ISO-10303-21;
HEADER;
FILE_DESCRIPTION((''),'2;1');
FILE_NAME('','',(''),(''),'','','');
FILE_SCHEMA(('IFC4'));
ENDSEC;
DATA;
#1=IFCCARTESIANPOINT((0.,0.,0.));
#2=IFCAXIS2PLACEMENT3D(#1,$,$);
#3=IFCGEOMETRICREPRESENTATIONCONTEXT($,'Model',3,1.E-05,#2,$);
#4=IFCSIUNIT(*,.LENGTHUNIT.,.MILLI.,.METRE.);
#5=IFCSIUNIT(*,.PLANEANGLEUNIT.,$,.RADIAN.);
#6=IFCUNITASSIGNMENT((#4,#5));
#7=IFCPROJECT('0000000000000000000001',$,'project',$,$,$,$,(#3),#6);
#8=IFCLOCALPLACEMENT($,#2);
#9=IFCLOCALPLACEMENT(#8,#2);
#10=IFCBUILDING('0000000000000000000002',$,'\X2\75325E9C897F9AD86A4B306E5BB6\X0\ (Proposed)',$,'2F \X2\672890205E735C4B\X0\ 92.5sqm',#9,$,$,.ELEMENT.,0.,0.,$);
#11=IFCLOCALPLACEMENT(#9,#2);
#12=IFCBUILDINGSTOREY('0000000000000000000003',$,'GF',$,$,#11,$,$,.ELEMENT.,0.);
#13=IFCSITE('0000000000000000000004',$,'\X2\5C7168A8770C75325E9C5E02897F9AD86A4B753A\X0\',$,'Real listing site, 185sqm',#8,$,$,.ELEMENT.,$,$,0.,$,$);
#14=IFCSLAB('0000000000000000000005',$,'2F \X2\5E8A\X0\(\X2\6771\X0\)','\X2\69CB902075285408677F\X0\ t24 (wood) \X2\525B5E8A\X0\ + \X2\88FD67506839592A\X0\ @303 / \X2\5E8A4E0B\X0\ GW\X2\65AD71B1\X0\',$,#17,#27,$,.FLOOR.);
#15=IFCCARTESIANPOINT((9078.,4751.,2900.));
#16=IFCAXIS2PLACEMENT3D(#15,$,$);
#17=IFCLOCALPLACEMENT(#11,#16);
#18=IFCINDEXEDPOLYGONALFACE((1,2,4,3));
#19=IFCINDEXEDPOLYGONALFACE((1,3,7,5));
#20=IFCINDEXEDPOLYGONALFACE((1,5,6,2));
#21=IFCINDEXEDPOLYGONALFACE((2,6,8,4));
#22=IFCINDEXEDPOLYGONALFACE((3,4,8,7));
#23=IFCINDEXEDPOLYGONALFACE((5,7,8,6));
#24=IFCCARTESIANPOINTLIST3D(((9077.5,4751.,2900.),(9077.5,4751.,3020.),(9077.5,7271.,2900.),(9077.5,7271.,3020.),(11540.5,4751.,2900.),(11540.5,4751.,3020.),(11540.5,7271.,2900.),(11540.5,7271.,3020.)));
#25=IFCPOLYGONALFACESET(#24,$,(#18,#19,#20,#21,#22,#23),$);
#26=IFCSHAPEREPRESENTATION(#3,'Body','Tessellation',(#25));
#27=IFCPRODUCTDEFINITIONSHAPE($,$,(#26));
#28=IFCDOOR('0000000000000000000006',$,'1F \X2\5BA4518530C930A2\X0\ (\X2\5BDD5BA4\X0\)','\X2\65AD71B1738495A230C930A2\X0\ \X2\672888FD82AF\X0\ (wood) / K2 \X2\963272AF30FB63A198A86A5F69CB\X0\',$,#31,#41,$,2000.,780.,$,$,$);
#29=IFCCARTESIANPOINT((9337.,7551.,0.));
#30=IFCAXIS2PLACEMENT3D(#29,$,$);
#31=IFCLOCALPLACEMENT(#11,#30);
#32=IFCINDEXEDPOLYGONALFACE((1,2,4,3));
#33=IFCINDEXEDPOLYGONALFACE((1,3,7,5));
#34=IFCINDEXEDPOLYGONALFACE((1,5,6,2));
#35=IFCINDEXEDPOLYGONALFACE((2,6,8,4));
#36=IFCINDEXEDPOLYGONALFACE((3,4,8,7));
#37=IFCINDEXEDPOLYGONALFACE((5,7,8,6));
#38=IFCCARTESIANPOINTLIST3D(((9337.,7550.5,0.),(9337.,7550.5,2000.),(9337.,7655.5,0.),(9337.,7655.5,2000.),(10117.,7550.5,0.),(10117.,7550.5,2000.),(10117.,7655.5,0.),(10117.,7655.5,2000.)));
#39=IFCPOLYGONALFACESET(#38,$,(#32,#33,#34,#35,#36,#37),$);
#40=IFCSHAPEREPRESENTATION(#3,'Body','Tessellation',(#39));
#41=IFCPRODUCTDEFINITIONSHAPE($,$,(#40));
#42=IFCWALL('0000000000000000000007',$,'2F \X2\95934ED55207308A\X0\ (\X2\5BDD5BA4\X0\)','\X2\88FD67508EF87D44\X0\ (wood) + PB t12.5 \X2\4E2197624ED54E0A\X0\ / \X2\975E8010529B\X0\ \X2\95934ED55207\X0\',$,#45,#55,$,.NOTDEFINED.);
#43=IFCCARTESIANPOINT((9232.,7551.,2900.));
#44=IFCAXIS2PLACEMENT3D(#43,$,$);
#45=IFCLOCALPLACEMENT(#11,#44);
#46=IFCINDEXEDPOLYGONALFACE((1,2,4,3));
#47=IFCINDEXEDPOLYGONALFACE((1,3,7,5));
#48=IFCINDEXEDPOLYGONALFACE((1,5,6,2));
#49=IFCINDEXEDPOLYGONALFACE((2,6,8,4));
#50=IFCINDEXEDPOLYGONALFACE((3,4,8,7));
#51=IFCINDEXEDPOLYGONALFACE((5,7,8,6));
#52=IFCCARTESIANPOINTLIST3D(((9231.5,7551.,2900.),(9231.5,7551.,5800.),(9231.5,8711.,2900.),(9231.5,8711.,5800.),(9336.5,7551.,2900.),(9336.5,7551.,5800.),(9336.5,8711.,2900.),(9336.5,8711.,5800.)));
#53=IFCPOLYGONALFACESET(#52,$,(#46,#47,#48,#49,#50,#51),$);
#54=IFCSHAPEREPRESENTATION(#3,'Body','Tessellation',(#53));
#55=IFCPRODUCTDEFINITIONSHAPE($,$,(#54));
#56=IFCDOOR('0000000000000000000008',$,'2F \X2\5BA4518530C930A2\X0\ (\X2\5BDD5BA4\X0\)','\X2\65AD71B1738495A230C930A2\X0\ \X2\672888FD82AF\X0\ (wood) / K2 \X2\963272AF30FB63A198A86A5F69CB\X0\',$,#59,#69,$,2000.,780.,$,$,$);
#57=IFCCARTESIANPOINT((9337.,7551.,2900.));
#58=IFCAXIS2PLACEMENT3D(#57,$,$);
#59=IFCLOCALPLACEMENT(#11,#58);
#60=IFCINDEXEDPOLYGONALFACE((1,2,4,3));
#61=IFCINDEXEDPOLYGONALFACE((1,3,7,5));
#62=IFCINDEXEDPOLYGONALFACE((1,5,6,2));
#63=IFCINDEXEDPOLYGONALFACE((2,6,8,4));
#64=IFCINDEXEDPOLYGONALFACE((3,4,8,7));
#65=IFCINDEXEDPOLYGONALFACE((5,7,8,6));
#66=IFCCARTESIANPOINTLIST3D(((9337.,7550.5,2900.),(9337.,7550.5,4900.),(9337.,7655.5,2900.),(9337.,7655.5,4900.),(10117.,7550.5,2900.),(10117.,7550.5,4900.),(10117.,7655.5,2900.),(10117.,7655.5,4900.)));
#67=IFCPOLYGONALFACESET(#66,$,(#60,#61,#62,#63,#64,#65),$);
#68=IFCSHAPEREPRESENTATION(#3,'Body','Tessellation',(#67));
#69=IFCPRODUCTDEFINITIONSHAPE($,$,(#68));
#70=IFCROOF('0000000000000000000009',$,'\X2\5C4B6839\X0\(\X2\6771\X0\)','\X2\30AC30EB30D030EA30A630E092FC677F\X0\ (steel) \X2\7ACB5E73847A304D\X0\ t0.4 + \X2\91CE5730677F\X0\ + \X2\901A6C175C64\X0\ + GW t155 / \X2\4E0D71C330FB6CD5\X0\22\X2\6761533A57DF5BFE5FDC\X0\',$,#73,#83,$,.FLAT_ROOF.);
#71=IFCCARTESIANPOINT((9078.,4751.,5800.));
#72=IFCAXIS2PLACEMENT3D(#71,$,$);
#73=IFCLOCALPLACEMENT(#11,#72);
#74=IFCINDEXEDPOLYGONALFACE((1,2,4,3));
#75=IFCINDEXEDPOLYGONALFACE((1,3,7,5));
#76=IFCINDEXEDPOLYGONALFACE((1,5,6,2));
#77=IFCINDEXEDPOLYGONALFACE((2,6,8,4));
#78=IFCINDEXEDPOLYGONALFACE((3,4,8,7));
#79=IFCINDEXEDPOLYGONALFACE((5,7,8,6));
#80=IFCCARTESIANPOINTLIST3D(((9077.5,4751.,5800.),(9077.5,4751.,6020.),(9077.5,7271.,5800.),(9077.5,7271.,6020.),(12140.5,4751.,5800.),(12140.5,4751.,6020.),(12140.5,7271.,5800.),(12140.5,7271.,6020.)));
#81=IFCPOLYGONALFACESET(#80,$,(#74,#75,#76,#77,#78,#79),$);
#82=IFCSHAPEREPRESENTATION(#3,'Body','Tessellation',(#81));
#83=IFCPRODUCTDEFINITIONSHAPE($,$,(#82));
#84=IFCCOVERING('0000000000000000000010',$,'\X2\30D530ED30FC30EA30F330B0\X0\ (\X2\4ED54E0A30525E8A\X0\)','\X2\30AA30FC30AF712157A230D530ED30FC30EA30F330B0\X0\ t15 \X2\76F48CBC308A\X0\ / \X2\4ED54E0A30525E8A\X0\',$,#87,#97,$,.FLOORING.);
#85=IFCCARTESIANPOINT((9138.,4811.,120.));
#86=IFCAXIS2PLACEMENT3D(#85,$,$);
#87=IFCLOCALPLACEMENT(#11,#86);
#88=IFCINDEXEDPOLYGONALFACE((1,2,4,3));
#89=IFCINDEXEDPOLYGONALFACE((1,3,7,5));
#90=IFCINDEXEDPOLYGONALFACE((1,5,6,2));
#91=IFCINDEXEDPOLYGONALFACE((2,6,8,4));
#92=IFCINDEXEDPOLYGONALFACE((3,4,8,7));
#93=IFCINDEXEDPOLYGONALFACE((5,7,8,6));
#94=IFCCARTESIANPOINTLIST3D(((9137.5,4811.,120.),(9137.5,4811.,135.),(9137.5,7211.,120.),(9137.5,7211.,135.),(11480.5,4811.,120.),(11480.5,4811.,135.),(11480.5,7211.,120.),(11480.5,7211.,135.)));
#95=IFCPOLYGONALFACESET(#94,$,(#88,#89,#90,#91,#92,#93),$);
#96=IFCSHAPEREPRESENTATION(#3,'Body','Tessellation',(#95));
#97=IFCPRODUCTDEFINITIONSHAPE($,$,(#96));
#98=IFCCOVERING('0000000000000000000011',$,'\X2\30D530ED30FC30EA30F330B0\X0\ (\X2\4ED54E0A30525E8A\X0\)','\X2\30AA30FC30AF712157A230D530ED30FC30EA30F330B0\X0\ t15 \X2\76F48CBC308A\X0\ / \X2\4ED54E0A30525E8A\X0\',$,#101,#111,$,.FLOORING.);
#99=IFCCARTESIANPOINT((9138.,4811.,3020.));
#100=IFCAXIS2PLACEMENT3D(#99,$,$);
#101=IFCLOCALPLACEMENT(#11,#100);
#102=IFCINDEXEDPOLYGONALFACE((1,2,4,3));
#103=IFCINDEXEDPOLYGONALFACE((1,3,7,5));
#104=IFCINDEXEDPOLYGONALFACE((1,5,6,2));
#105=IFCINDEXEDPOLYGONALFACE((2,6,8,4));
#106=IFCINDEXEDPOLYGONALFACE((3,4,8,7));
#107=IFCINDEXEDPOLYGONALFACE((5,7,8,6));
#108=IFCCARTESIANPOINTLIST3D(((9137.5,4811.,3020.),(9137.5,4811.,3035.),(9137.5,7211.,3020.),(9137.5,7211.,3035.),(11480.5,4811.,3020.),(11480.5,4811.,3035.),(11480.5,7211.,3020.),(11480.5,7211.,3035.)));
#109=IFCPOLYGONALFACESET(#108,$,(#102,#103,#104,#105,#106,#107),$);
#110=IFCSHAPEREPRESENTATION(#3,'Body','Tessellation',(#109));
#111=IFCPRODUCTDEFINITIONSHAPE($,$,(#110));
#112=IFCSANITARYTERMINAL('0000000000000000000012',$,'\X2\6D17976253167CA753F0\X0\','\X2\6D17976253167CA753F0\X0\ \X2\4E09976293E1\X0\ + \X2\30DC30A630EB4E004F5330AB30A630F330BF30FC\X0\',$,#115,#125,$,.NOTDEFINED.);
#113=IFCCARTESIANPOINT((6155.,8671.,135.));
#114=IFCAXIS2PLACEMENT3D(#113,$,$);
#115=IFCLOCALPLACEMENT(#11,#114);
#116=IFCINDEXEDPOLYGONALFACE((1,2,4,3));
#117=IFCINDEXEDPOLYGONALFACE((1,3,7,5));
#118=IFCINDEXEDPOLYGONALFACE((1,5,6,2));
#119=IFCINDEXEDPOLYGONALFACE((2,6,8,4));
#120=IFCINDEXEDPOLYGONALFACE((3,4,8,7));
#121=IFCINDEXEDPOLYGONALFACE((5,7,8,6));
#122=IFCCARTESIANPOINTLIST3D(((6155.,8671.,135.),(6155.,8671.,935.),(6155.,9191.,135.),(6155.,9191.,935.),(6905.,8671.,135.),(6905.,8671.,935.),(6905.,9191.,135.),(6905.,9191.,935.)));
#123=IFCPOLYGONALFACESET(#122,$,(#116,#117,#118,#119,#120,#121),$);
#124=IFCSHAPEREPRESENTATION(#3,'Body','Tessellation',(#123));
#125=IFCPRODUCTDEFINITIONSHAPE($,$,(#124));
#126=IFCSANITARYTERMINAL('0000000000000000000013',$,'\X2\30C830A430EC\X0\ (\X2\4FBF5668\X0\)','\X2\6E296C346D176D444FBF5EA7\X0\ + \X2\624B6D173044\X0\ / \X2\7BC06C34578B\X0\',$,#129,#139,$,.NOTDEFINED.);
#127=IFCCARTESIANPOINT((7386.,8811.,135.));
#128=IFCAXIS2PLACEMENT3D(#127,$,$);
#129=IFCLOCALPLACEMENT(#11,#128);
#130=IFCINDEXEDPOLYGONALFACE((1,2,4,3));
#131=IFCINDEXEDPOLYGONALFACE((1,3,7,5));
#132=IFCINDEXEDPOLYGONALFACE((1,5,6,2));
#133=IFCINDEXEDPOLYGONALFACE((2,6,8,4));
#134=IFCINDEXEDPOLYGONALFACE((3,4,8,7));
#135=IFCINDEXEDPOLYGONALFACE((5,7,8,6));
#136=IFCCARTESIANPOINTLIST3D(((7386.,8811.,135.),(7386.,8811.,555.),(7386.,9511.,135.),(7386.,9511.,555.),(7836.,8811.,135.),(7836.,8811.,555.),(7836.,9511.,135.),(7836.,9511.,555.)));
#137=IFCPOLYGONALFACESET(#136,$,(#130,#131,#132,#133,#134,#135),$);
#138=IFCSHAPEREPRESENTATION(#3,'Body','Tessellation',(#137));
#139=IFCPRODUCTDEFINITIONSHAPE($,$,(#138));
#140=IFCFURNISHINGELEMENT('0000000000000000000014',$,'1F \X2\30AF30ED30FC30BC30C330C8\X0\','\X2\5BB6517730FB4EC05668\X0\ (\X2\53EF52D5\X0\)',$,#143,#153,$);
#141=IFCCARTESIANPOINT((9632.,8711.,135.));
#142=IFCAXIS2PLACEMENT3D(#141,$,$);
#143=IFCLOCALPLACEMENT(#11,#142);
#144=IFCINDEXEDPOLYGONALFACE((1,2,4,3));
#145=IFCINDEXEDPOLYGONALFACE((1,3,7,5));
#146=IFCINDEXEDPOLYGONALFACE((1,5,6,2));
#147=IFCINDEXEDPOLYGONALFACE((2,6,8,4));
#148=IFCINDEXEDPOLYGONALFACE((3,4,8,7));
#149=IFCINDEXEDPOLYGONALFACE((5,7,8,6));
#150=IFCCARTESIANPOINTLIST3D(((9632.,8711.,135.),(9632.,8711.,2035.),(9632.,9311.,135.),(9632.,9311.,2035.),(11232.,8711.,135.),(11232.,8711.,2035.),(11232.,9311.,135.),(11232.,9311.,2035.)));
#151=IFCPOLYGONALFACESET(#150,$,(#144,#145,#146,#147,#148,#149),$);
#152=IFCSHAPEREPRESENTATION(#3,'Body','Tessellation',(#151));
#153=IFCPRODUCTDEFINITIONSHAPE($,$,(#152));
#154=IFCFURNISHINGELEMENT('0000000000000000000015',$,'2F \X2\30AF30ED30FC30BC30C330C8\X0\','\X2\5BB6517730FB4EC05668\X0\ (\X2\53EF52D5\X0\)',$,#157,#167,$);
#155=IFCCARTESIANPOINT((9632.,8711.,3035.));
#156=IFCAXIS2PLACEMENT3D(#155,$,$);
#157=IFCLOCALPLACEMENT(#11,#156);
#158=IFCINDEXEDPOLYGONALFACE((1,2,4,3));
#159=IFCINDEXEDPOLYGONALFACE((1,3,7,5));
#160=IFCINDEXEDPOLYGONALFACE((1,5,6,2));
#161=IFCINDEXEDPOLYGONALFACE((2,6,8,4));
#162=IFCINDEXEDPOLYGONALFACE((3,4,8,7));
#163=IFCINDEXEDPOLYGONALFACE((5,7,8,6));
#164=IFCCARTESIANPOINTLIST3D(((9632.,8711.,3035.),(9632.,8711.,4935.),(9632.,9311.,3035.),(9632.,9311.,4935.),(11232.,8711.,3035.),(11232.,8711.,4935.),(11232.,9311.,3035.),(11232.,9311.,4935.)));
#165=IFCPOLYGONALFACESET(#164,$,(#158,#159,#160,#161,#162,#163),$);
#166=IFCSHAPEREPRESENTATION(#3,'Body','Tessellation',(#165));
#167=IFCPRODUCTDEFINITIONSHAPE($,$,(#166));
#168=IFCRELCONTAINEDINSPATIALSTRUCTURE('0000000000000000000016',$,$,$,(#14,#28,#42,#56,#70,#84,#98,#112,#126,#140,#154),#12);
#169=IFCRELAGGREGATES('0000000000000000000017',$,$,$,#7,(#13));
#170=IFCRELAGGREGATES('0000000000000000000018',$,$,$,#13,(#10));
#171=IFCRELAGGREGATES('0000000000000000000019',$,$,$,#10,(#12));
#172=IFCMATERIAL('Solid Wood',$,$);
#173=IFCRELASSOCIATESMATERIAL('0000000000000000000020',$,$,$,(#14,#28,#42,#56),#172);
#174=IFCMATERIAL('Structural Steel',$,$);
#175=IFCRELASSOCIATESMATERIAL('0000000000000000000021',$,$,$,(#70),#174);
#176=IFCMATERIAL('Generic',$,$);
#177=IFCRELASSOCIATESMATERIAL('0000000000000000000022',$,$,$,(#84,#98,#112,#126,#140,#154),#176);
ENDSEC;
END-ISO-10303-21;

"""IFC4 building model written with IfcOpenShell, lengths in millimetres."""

from ifc_helpers import new_model, si_unit, frame, frame_2d, origin, place, context, project, spatial, rectangle, extrude, material, element, save


model = new_model("IFC4")

# Units and contexts
model_context = context("Model", 3, precision=1e-05, world=origin())
ifc_project = project(units=[si_unit("LENGTHUNIT", "METRE", prefix="MILLI"), si_unit("PLANEANGLEUNIT", "RADIAN")], contexts=[model_context])

# Site, building, storey
site_placement = place(None, origin())
site = spatial("IfcSite", under=ifc_project, at=site_placement, Name="山梨県甲府市西高橋町", ObjectType="Real listing site, 185sqm", CompositionType="ELEMENT", RefElevation=0.0)
building_placement = place(site_placement, origin())
building = spatial("IfcBuilding", under=site, at=building_placement, Name="甲府西高橋の家 (Proposed)", ObjectType="2F 木造平屋 92.5sqm", CompositionType="ELEMENT", ElevationOfRefHeight=0.0, ElevationOfTerrain=0.0)
storey_placement = place(building_placement, origin())
storey = spatial("IfcBuildingStorey", under=building, at=storey_placement, Name="GF", CompositionType="ELEMENT", Elevation=0.0)

# Slab
ifc_material_1 = material(Name="Solid Wood")
slab_1_placement = place(storey_placement, frame((9078.0, 4751.0, 2900.0)))
element("IfcSlab", 1, at=slab_1_placement, inside=storey, material=ifc_material_1, Name="2F 床(東)", Description="構造用合板 t24 (wood) 剛床 + 製材根太 @303 / 床下 GW断熱", PredefinedType="FLOOR", context=model_context, shape_type="SweptSolid", body=[
    extrude(rectangle(XDim=2463.0, YDim=2520.0, at=frame_2d((1231.0, 1260.0))), frame((9078.0, 4751.0, 2900.0)), (0.0, 0.0, 1.0), 120.0),
])

# Door
door_1_placement = place(storey_placement, frame((9337.0, 7551.0, 0.0)))
element("IfcDoor", 2, at=door_1_placement, inside=storey, material=ifc_material_1, Name="1F 室内ドア (寝室)", Description="断熱玄関ドア 木製芯 (wood) / K2 防犯・採風機構", OverallHeight=2000.0, OverallWidth=780.0, context=model_context, shape_type="SweptSolid", body=[
    extrude(rectangle(XDim=780.0, YDim=105.0, at=frame_2d((390.0, 52.0))), frame((9337.0, 7551.0, 0.0)), (0.0, 0.0, 1.0), 2000.0),
])

# Wall
wall_1_placement = place(storey_placement, frame((9232.0, 7551.0, 2900.0)))
element("IfcWall", 3, at=wall_1_placement, inside=storey, material=ifc_material_1, Name="2F 間仕切り (寝室)", Description="製材軸組 (wood) + PB t12.5 両面仕上 / 非耐力 間仕切", PredefinedType="NOTDEFINED", context=model_context, shape_type="SweptSolid", body=[
    extrude(rectangle(XDim=105.0, YDim=1160.0, at=frame_2d((52.0, 580.0))), frame((9232.0, 7551.0, 2900.0)), (0.0, 0.0, 1.0), 2900.0),
])

# Door
door_2_placement = place(storey_placement, frame((9337.0, 7551.0, 2900.0)))
element("IfcDoor", 4, at=door_2_placement, inside=storey, material=ifc_material_1, Name="2F 室内ドア (寝室)", Description="断熱玄関ドア 木製芯 (wood) / K2 防犯・採風機構", OverallHeight=2000.0, OverallWidth=780.0, context=model_context, shape_type="SweptSolid", body=[
    extrude(rectangle(XDim=780.0, YDim=105.0, at=frame_2d((390.0, 52.0))), frame((9337.0, 7551.0, 2900.0)), (0.0, 0.0, 1.0), 2000.0),
])

# Roof
ifc_material_2 = material(Name="Structural Steel")
for number, where, name in (
    (5, (9078.0, 4751.0, 5800.0), "屋根(東)"),
):
    element("IfcRoof", number, at=place(storey_placement, frame(where)), inside=storey, material=ifc_material_2, Name=name, Description="ガルバリウム鋼板 (steel) 立平葺き t0.4 + 野地板 + 通気層 + GW t155 / 不燃・法22条区域対応", PredefinedType="FLAT_ROOF", context=model_context, shape_type="SweptSolid", body=[
        extrude(rectangle(XDim=3063.0, YDim=2520.0, at=frame_2d((1531.0, 1260.0))), frame((9078.0, 4751.0, 5800.0)), (0.0, 0.0, 1.0), 220.0),
    ])

# Coverings
ifc_material_3 = material(Name="Generic")
covering_1_placement = place(storey_placement, frame((9138.0, 4811.0, 120.0)))
element("IfcCovering", 6, at=covering_1_placement, inside=storey, material=ifc_material_3, Name="フローリング (仕上げ床)", Description="オーク無垢フローリング t15 直貼り / 仕上げ床", PredefinedType="FLOORING", context=model_context, shape_type="SweptSolid", body=[
    extrude(rectangle(XDim=2343.0, YDim=2400.0, at=frame_2d((1171.0, 1200.0))), frame((9138.0, 4811.0, 120.0)), (0.0, 0.0, 1.0), 15.0),
])
covering_2_placement = place(storey_placement, frame((9138.0, 4811.0, 3020.0)))
element("IfcCovering", 7, at=covering_2_placement, inside=storey, material=ifc_material_3, Name="フローリング (仕上げ床)", Description="オーク無垢フローリング t15 直貼り / 仕上げ床", PredefinedType="FLOORING", context=model_context, shape_type="SweptSolid", body=[
    extrude(rectangle(XDim=2343.0, YDim=2400.0, at=frame_2d((1171.0, 1200.0))), frame((9138.0, 4811.0, 3020.0)), (0.0, 0.0, 1.0), 15.0),
])

# Sanitary terminals
sanitary_terminal_1_placement = place(storey_placement, frame((6155.0, 8671.0, 135.0)))
element("IfcSanitaryTerminal", 8, at=sanitary_terminal_1_placement, inside=storey, material=ifc_material_3, Name="洗面化粧台", Description="洗面化粧台 三面鏡 + ボウル一体カウンター", PredefinedType="NOTDEFINED", context=model_context, shape_type="SweptSolid", body=[
    extrude(rectangle(XDim=750.0, YDim=520.0, at=frame_2d((375.0, 260.0))), frame((6155.0, 8671.0, 135.0)), (0.0, 0.0, 1.0), 800.0),
])
sanitary_terminal_2_placement = place(storey_placement, frame((7386.0, 8811.0, 135.0)))
element("IfcSanitaryTerminal", 9, at=sanitary_terminal_2_placement, inside=storey, material=ifc_material_3, Name="トイレ (便器)", Description="温水洗浄便座 + 手洗い / 節水型", PredefinedType="NOTDEFINED", context=model_context, shape_type="SweptSolid", body=[
    extrude(rectangle(XDim=450.0, YDim=700.0, at=frame_2d((225.0, 350.0))), frame((7386.0, 8811.0, 135.0)), (0.0, 0.0, 1.0), 420.0),
])

# Furnishing elements
furnishing_1_placement = place(storey_placement, frame((9632.0, 8711.0, 135.0)))
element("IfcFurnishingElement", 10, at=furnishing_1_placement, inside=storey, material=ifc_material_3, Name="1F クローゼット", Description="家具・什器 (可動)", context=model_context, shape_type="SweptSolid", body=[
    extrude(rectangle(XDim=1600.0, YDim=600.0, at=frame_2d((800.0, 300.0))), frame((9632.0, 8711.0, 135.0)), (0.0, 0.0, 1.0), 1900.0),
])
furnishing_2_placement = place(storey_placement, frame((9632.0, 8711.0, 3035.0)))
element("IfcFurnishingElement", 11, at=furnishing_2_placement, inside=storey, material=ifc_material_3, Name="2F クローゼット", Description="家具・什器 (可動)", context=model_context, shape_type="SweptSolid", body=[
    extrude(rectangle(XDim=1600.0, YDim=600.0, at=frame_2d((800.0, 300.0))), frame((9632.0, 8711.0, 3035.0)), (0.0, 0.0, 1.0), 1900.0),
])

save(model, "model.ifc")
